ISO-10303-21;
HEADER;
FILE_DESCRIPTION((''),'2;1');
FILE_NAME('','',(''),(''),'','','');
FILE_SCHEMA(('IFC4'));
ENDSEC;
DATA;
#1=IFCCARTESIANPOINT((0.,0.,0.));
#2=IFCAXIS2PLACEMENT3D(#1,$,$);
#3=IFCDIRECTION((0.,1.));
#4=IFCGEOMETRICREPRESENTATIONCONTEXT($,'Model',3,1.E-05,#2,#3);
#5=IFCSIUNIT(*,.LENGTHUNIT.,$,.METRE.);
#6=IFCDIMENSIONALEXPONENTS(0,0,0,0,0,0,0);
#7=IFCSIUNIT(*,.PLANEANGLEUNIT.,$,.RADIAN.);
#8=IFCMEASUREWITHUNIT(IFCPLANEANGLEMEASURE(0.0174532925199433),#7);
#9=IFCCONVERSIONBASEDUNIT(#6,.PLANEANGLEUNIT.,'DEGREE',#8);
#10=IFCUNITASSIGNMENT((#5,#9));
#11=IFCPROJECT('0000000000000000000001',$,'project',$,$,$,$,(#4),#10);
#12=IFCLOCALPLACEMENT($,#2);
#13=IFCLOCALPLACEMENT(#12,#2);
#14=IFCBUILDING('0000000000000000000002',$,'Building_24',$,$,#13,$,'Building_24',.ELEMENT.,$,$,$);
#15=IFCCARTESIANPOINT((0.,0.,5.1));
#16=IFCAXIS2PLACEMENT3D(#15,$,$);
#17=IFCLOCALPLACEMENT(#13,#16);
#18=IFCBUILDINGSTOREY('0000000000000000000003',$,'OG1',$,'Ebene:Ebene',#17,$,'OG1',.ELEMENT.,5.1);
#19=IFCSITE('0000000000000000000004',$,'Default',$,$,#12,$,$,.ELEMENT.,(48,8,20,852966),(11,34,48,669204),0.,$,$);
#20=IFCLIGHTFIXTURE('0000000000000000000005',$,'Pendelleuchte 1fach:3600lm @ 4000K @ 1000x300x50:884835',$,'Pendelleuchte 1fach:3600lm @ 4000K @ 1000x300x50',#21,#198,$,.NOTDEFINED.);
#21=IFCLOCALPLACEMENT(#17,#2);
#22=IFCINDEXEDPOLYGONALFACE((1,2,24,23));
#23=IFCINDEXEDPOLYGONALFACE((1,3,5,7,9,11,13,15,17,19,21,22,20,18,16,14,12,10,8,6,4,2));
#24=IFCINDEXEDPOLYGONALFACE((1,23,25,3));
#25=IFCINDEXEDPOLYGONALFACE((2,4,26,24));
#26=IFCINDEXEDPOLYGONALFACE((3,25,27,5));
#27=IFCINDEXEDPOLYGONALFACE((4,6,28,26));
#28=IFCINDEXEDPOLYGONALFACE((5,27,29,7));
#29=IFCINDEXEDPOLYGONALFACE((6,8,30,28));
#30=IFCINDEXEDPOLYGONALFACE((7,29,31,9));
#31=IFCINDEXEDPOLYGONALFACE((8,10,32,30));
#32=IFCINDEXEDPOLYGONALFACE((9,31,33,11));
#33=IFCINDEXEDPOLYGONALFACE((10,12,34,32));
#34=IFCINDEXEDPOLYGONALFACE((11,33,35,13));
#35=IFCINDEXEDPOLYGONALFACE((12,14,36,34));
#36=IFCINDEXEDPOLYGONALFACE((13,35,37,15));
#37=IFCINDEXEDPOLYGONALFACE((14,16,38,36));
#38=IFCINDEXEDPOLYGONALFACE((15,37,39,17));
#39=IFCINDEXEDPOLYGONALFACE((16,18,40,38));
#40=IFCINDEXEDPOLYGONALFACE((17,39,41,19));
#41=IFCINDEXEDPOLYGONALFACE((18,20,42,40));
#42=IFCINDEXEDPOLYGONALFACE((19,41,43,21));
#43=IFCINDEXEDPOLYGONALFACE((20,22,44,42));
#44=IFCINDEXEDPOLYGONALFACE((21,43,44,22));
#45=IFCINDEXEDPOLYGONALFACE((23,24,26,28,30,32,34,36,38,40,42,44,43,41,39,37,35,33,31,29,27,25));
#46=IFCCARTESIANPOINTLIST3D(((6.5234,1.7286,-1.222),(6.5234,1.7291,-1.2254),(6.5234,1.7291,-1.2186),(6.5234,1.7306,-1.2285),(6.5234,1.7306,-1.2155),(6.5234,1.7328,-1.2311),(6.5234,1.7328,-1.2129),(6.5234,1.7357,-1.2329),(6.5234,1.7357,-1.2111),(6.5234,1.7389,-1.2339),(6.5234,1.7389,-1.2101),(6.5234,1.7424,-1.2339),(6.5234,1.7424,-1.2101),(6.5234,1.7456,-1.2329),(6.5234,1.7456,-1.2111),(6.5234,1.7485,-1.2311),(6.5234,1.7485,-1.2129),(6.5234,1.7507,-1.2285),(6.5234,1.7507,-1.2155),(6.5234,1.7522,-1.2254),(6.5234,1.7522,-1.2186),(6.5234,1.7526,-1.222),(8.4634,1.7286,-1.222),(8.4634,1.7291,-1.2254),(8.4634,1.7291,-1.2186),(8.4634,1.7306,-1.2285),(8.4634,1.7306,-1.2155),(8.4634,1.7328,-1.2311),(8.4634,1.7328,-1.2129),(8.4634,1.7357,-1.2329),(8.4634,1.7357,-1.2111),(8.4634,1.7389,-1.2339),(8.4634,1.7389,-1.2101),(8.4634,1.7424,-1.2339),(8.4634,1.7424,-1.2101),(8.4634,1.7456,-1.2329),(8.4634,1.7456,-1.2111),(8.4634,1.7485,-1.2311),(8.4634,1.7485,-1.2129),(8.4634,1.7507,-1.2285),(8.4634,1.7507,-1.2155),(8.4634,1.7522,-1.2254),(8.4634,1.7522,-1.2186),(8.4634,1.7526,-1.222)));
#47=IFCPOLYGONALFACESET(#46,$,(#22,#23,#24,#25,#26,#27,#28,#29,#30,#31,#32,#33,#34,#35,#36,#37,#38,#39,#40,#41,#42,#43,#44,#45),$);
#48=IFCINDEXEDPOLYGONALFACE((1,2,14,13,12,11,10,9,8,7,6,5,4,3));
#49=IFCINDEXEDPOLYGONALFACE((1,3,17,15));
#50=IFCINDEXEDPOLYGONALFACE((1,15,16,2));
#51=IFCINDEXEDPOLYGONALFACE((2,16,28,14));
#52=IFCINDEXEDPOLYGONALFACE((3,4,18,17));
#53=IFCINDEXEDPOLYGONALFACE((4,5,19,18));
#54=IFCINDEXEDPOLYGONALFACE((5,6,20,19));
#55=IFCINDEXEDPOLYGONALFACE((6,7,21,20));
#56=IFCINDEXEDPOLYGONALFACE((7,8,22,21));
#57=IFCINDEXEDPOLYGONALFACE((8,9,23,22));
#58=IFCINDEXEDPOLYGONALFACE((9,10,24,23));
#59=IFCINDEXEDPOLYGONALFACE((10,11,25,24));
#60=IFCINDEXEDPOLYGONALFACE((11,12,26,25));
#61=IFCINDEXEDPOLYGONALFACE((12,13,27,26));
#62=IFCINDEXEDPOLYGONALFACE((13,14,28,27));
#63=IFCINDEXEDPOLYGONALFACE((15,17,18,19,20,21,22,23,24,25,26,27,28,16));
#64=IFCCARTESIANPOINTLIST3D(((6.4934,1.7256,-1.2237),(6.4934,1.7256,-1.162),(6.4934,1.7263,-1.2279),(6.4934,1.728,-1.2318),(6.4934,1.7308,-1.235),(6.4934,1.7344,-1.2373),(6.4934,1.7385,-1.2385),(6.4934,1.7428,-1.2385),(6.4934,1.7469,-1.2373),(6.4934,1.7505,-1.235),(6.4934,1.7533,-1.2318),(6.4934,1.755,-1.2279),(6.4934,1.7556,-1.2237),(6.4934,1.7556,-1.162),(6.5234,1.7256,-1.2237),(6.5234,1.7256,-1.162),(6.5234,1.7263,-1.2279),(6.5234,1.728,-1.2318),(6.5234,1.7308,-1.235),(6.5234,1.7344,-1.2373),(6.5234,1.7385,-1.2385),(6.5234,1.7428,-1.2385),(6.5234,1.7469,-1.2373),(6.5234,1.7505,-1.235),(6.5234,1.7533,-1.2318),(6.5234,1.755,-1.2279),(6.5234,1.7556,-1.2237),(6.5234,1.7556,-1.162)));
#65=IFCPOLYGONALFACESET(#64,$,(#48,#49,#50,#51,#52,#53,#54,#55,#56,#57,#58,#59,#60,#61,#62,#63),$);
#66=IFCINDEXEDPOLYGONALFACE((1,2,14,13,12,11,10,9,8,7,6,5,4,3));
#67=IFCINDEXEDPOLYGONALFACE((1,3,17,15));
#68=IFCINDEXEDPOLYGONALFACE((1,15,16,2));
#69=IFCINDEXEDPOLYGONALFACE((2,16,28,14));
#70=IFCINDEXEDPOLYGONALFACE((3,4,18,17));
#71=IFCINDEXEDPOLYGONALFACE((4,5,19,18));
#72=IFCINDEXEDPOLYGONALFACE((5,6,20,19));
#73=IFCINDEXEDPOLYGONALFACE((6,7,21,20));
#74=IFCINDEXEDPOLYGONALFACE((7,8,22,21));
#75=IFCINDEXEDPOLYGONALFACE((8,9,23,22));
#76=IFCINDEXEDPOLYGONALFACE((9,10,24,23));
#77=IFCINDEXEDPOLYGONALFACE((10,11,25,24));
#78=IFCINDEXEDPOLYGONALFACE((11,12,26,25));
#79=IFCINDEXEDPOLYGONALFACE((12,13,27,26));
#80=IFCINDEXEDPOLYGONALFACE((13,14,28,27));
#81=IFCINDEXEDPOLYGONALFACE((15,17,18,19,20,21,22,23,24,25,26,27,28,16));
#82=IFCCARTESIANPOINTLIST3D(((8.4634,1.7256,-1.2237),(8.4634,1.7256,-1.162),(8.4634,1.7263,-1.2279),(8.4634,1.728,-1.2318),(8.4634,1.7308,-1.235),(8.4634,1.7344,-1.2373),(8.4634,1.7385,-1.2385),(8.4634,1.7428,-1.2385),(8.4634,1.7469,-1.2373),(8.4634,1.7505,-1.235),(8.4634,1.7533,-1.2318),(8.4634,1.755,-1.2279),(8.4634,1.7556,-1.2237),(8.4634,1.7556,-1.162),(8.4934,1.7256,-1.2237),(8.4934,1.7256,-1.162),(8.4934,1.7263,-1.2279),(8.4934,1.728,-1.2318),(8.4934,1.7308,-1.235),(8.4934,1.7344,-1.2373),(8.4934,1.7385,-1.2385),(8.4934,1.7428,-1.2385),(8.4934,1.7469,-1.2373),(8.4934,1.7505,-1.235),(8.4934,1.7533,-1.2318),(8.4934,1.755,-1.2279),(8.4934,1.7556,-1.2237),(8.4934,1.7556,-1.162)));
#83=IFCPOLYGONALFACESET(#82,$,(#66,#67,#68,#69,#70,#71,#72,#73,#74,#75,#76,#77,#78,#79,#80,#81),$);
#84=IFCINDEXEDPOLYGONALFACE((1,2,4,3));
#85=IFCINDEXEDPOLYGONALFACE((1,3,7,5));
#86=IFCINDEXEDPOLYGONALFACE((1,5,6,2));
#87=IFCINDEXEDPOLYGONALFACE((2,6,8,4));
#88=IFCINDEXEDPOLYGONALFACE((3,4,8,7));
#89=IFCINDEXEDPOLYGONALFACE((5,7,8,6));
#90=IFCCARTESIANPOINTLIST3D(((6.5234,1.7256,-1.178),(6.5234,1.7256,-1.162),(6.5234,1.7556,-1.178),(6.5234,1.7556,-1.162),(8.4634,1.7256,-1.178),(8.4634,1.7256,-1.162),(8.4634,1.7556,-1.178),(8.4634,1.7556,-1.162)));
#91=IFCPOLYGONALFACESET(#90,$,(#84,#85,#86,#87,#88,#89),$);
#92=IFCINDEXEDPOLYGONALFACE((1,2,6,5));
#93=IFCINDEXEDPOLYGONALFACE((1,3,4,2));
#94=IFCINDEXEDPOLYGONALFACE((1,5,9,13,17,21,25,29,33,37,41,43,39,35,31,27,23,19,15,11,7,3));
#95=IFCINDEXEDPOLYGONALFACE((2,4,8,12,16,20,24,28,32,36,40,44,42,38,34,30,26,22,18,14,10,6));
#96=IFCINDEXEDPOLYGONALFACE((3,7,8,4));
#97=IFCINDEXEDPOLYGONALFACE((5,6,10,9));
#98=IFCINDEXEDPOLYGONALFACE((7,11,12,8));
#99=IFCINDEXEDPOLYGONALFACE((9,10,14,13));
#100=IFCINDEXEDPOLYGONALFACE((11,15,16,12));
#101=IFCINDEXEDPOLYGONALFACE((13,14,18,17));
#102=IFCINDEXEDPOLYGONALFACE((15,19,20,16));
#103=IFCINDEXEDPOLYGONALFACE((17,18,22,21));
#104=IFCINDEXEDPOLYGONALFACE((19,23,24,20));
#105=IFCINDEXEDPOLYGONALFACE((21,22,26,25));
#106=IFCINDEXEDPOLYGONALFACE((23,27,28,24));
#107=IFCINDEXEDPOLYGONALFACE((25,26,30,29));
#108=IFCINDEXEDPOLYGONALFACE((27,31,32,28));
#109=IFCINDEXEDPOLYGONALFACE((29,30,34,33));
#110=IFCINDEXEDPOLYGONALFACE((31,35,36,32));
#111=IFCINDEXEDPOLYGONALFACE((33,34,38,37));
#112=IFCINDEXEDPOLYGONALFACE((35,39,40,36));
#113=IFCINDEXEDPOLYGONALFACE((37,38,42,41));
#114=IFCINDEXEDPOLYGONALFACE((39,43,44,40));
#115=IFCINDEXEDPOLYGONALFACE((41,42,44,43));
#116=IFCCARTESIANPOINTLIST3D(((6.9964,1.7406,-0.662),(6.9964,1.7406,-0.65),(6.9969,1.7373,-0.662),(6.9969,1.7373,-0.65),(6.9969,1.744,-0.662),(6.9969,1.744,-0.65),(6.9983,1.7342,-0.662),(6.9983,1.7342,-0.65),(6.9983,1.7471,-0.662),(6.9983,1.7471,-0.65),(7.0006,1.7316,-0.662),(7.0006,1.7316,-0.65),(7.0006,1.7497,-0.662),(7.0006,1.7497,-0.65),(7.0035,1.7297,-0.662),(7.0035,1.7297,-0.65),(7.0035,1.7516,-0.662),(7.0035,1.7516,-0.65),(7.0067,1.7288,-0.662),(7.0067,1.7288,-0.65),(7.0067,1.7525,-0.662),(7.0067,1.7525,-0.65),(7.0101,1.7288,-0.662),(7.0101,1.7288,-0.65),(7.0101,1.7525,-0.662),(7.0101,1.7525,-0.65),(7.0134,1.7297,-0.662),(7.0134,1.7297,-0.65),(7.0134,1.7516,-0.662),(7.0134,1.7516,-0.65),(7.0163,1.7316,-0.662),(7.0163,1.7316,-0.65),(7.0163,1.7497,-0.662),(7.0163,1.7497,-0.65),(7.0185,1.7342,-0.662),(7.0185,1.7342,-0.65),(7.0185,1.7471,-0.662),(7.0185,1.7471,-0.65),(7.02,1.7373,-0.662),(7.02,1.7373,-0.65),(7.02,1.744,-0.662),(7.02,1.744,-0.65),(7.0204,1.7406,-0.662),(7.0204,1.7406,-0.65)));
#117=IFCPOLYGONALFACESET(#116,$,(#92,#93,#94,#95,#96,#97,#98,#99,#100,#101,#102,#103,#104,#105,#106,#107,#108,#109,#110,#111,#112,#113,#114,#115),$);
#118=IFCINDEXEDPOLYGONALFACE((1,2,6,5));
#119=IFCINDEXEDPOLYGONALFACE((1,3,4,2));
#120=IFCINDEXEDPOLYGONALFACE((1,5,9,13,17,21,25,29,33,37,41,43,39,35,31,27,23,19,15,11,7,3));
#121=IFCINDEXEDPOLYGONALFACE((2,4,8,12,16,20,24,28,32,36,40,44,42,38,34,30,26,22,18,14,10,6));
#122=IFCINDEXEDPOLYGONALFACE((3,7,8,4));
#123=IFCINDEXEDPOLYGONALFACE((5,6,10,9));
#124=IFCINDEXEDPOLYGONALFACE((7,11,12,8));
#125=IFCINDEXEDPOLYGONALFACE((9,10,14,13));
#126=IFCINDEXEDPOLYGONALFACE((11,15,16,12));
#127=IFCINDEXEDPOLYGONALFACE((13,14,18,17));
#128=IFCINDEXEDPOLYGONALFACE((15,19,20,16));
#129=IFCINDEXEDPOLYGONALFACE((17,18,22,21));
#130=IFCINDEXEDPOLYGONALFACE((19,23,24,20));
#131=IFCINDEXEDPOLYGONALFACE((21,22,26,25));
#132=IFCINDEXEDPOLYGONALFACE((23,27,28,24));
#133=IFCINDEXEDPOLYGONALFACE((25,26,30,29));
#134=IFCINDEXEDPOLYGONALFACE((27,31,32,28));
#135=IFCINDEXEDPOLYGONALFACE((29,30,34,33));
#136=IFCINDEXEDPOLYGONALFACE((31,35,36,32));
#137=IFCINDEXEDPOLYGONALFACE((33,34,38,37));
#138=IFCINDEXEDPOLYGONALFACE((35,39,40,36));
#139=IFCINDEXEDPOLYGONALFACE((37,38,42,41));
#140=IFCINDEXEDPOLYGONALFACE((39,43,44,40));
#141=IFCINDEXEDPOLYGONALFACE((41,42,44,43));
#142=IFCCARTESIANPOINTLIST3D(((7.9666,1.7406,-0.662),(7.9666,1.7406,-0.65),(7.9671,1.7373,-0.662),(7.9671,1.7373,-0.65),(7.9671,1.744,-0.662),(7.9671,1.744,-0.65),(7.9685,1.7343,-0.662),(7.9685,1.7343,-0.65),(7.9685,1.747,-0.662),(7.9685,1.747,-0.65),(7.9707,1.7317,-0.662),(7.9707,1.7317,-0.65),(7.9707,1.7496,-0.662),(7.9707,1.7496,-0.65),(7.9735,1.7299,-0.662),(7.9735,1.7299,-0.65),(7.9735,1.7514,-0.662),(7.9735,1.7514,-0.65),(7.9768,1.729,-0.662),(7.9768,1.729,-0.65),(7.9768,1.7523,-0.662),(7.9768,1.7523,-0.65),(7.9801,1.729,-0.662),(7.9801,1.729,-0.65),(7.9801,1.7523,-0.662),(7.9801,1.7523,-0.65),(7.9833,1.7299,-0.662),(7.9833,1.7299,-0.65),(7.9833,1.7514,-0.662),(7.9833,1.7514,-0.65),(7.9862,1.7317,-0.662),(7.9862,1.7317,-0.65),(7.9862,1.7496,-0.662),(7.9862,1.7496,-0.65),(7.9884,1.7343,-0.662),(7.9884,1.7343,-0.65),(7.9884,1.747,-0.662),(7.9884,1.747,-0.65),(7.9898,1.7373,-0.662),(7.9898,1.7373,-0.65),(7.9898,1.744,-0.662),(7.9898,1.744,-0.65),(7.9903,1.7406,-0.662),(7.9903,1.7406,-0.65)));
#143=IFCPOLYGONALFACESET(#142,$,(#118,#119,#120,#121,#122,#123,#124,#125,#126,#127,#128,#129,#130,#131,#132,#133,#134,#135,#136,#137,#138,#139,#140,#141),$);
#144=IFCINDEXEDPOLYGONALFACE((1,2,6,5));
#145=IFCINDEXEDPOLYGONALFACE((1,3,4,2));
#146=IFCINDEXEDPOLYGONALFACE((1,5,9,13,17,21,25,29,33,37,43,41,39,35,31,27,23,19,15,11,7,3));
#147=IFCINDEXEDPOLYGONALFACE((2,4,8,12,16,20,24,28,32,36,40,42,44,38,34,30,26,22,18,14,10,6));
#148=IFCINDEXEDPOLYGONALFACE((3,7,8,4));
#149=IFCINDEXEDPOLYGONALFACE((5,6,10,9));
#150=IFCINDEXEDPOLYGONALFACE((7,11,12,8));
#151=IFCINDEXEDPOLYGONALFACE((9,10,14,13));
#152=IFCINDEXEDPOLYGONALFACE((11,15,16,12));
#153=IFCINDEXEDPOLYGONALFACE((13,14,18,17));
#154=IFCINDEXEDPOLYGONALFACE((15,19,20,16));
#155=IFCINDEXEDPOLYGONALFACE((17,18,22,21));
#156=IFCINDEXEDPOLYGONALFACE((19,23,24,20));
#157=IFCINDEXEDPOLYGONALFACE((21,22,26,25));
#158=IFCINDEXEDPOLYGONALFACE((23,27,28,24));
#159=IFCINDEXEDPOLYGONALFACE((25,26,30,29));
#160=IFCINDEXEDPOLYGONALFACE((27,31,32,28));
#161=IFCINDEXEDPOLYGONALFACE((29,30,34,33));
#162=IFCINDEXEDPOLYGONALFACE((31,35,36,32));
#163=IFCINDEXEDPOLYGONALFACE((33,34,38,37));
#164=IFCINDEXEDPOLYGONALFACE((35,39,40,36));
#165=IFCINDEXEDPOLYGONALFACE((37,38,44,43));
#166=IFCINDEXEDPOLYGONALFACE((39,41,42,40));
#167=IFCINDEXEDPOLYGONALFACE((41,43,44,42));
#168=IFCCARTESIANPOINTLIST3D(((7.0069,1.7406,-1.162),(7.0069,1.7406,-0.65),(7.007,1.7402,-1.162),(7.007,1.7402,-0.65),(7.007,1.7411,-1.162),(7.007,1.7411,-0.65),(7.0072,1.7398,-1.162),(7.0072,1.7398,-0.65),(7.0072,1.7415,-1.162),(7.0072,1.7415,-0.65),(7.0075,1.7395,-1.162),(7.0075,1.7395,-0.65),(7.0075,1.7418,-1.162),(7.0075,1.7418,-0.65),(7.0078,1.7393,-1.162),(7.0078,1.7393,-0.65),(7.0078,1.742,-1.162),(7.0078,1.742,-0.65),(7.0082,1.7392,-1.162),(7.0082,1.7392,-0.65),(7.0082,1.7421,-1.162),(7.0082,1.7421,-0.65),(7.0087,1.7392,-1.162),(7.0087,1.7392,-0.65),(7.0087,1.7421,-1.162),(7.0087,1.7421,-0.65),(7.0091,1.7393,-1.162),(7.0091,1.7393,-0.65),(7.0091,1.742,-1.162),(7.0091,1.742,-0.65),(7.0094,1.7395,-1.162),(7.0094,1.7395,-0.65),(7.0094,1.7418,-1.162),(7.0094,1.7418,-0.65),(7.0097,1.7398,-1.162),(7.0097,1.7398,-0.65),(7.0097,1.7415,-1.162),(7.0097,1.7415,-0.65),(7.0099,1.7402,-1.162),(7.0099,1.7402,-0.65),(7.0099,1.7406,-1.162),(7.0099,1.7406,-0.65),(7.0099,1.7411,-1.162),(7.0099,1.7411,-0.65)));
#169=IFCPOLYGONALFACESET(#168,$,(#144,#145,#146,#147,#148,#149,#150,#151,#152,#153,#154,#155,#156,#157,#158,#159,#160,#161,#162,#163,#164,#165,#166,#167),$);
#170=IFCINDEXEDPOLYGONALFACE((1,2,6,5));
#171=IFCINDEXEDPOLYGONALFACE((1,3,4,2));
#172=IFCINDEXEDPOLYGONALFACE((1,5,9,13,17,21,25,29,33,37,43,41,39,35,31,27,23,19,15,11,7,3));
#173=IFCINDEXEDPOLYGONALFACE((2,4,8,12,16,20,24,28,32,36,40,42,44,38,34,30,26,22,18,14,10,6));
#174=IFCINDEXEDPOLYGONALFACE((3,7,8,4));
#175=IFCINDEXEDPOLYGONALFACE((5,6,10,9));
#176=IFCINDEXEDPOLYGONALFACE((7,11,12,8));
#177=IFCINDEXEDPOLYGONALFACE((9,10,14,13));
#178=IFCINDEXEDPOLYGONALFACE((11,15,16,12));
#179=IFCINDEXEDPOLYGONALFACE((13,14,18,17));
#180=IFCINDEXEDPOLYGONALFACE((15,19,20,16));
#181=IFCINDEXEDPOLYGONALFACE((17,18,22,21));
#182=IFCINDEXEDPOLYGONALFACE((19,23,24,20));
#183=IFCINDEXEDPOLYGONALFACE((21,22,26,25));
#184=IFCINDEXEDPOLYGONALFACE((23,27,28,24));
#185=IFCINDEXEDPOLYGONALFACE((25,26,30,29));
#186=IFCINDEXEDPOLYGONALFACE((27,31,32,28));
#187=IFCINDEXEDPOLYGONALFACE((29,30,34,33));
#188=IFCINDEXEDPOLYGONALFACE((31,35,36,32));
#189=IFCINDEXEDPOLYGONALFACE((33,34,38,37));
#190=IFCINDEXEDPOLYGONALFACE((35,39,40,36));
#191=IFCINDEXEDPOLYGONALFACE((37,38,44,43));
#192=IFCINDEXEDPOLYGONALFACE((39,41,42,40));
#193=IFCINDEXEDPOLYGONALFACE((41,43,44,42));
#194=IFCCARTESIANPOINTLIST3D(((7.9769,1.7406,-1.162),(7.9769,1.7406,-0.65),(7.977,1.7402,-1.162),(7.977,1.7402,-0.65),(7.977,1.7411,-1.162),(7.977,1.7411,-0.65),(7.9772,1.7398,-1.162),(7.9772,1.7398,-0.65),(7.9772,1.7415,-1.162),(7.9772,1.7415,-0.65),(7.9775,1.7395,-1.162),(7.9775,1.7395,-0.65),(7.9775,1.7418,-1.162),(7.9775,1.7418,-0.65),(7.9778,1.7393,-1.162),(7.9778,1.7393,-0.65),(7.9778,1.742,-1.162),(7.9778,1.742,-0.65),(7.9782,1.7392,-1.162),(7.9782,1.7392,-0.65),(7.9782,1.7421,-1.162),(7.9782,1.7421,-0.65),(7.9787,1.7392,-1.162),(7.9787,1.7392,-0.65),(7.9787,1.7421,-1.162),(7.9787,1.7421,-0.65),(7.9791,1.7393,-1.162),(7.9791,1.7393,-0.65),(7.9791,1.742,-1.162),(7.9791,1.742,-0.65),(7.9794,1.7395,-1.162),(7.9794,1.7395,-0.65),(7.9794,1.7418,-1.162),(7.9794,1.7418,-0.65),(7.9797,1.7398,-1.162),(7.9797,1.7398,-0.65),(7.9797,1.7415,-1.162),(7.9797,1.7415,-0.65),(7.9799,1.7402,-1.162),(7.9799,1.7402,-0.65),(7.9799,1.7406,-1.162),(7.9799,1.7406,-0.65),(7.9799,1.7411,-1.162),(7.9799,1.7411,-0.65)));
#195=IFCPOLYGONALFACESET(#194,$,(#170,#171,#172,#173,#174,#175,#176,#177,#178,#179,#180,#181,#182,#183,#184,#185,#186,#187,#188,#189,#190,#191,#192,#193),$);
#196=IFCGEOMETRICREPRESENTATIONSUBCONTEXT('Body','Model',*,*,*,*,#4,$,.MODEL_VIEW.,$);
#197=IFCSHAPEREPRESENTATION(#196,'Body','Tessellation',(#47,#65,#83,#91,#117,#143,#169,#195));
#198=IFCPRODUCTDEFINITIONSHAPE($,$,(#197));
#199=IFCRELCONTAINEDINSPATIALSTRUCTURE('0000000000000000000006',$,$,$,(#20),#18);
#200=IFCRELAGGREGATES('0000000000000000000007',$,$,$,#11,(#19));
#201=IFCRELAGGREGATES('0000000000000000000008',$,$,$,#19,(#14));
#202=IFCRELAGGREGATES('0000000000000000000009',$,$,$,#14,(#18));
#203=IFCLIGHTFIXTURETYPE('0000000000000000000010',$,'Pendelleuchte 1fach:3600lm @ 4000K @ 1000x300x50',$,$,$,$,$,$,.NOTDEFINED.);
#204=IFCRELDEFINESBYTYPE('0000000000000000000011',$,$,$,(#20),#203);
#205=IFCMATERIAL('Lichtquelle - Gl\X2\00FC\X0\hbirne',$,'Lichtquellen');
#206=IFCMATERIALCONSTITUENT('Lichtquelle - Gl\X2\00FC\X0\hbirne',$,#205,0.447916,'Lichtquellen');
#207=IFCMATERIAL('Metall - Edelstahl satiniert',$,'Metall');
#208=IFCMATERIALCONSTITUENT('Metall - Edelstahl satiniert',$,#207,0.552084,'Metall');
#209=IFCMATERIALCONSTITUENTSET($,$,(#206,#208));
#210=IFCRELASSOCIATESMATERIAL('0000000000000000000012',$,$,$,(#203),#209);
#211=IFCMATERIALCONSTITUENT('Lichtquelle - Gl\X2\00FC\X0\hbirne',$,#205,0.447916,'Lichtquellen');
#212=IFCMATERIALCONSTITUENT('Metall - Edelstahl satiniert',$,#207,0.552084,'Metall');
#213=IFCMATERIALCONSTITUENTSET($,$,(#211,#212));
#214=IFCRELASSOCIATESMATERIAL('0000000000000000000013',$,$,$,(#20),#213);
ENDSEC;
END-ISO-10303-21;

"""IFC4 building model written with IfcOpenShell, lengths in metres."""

from ifc_helpers import new_model, entity, si_unit, converted_unit, direction, frame, origin, place, context, subcontext, project, spatial, line, arc, indexed_curve, outline, extrude, source, transform, mapped, material, constituent, constituent_set, type_object, type_shapes, element, save


model = new_model("IFC4")

# Units and contexts
model_context = context("Model", 3, precision=1e-05, world=origin(), true_north=direction((0.0, 1.0)))
body_context = subcontext(model_context, "Body", "Model", "MODEL_VIEW")
ifc_project = project(units=[si_unit("LENGTHUNIT", "METRE"), converted_unit("PLANEANGLEUNIT", "DEGREE", entity("IfcPlaneAngleMeasure", 0.0174532925199433), si_unit("PLANEANGLEUNIT", "RADIAN"), dimensions=[0, 0, 0, 0, 0, 0, 0])], contexts=[model_context])

# Site, building, storey
site_placement = place(None, origin())
site = spatial("IfcSite", under=ifc_project, at=site_placement, Name="Default", CompositionType="ELEMENT", RefLatitude=(48, 8, 20, 852966), RefLongitude=(11, 34, 48, 669204), RefElevation=0.0)
building_placement = place(site_placement, origin())
building = spatial("IfcBuilding", under=site, at=building_placement, Name="Building_24", LongName="Building_24", CompositionType="ELEMENT")
storey_placement = place(building_placement, frame((0.0, 0.0, 5.1)))
storey = spatial("IfcBuildingStorey", under=building, at=storey_placement, Name="OG1", ObjectType="Ebene:Ebene", LongName="OG1", CompositionType="ELEMENT", Elevation=5.1)

# Light fixture
ifc_material_1 = material(Name="Lichtquelle - Glühbirne", Category="Lichtquellen")
ifc_constituent_1 = constituent(ifc_material_1, Name="Lichtquelle - Glühbirne", Category="Lichtquellen", fraction=0.447916)
ifc_material_2 = material(Name="Metall - Edelstahl satiniert", Category="Metall")
ifc_constituent_2 = constituent(ifc_material_2, Name="Metall - Edelstahl satiniert", Category="Metall", fraction=0.552084)
ifc_constituent_set_1 = constituent_set(constituents=[ifc_constituent_1, ifc_constituent_2])
ifc_constituent_3 = constituent(ifc_material_1, Name="Lichtquelle - Glühbirne", Category="Lichtquellen", fraction=0.447916)
ifc_constituent_4 = constituent(ifc_material_2, Name="Metall - Edelstahl satiniert", Category="Metall", fraction=0.552084)
ifc_constituent_set_2 = constituent_set(constituents=[ifc_constituent_3, ifc_constituent_4])
light_fixture_type = type_object("IfcLightFixtureType", Name="Pendelleuchte 1fach:3600lm @ 4000K @ 1000x300x50", PredefinedType="NOTDEFINED", material=ifc_constituent_set_2)
shared_shape_1 = source(origin(), body_context, "Body", "SweptSolid", [
    extrude(outline(indexed_curve([(-0.012, 0.0), (0.0, -0.012), (0.012, 0.0), (0.0, 0.012)], segments=[arc(1, 2, 3), arc(3, 4, 1)], self_intersect=False)), frame((-0.97, 0.0, -0.572), z_axis=(1.0, 0.0, 0.0), x_axis=(0.0, -1.0, 0.0)), (0.0, 0.0, 1.0), 1.94),
    extrude(outline(indexed_curve([(0.015, 0.0308), (0.0, 0.0458), (-0.015, 0.0308), (-0.015, -0.0308), (0.015, -0.0308)], segments=[arc(1, 2, 3), line(3, 4, 5, 1)], self_intersect=False)), frame((0.97, 0.0, -0.5428), z_axis=(1.0, 0.0, 0.0), x_axis=(0.0, -1.0, 0.0)), (0.0, 0.0, 1.0), 0.03),
    extrude(outline(indexed_curve([(0.015, 0.0308), (0.0, 0.0458), (-0.015, 0.0308), (-0.015, -0.0308), (0.015, -0.0308)], segments=[arc(1, 2, 3), line(3, 4, 5, 1)], self_intersect=False)), frame((-1.0, 0.0, -0.5428), z_axis=(1.0, 0.0, 0.0), x_axis=(0.0, -1.0, 0.0)), (0.0, 0.0, 1.0), 0.03),
    extrude(outline(indexed_curve([(-0.015, -0.97), (0.015, -0.97), (0.015, 0.97), (-0.015, 0.97), (-0.015, -0.97)], self_intersect=False)), frame((0.0, 0.0, -0.528), z_axis=(0.0, 0.0, 1.0), x_axis=(0.0, 1.0, 0.0)), (0.0, 0.0, 1.0), 0.016),
    extrude(outline(indexed_curve([(-0.012, 0.0), (0.0, -0.012), (0.012, 0.0), (0.0, 0.012)], segments=[arc(1, 2, 3), arc(3, 4, 1)], self_intersect=False)), frame((0.485, 0.0, -0.012)), (0.0, 0.0, 1.0), 0.012),
    extrude(outline(indexed_curve([(-0.0118, 0.0), (0.0, -0.0118), (0.0118, 0.0), (0.0, 0.0118)], segments=[arc(1, 2, 3), arc(3, 4, 1)], self_intersect=False)), frame((-0.485, 0.0, -0.012)), (0.0, 0.0, 1.0), 0.012),
    extrude(outline(indexed_curve([(-0.0015, 0.0), (0.0, -0.0015), (0.0015, 0.0), (0.0, 0.0015)], segments=[arc(1, 2, 3), arc(3, 4, 1)], self_intersect=False)), frame((0.485, 0.0, -0.512)), (0.0, 0.0, 1.0), 0.512),
    extrude(outline(indexed_curve([(-0.0015, 0.0), (0.0, -0.0015), (0.0015, 0.0), (0.0, 0.0015)], segments=[arc(1, 2, 3), arc(3, 4, 1)], self_intersect=False)), frame((-0.485, 0.0, -0.512)), (0.0, 0.0, 1.0), 0.512),
])
type_shapes(light_fixture_type, [shared_shape_1])
light_fixture_1_placement = place(storey_placement, frame((7.4934, 1.7406, -0.65), z_axis=(0.0, 0.0, 1.0), x_axis=(-1.0, 0.0, 0.0)))
element("IfcLightFixture", 1, at=light_fixture_1_placement, inside=storey, type_object=light_fixture_type, material=ifc_constituent_set_1, Name="Pendelleuchte 1fach:3600lm @ 4000K @ 1000x300x50:884835", ObjectType="Pendelleuchte 1fach:3600lm @ 4000K @ 1000x300x50", PredefinedType="NOTDEFINED", context=body_context, shape_type="MappedRepresentation", body=[
    mapped(shared_shape_1, transform((0.0, 0.0, 0.0), scale=1.0)),
])

save(model, "model.ifc")
